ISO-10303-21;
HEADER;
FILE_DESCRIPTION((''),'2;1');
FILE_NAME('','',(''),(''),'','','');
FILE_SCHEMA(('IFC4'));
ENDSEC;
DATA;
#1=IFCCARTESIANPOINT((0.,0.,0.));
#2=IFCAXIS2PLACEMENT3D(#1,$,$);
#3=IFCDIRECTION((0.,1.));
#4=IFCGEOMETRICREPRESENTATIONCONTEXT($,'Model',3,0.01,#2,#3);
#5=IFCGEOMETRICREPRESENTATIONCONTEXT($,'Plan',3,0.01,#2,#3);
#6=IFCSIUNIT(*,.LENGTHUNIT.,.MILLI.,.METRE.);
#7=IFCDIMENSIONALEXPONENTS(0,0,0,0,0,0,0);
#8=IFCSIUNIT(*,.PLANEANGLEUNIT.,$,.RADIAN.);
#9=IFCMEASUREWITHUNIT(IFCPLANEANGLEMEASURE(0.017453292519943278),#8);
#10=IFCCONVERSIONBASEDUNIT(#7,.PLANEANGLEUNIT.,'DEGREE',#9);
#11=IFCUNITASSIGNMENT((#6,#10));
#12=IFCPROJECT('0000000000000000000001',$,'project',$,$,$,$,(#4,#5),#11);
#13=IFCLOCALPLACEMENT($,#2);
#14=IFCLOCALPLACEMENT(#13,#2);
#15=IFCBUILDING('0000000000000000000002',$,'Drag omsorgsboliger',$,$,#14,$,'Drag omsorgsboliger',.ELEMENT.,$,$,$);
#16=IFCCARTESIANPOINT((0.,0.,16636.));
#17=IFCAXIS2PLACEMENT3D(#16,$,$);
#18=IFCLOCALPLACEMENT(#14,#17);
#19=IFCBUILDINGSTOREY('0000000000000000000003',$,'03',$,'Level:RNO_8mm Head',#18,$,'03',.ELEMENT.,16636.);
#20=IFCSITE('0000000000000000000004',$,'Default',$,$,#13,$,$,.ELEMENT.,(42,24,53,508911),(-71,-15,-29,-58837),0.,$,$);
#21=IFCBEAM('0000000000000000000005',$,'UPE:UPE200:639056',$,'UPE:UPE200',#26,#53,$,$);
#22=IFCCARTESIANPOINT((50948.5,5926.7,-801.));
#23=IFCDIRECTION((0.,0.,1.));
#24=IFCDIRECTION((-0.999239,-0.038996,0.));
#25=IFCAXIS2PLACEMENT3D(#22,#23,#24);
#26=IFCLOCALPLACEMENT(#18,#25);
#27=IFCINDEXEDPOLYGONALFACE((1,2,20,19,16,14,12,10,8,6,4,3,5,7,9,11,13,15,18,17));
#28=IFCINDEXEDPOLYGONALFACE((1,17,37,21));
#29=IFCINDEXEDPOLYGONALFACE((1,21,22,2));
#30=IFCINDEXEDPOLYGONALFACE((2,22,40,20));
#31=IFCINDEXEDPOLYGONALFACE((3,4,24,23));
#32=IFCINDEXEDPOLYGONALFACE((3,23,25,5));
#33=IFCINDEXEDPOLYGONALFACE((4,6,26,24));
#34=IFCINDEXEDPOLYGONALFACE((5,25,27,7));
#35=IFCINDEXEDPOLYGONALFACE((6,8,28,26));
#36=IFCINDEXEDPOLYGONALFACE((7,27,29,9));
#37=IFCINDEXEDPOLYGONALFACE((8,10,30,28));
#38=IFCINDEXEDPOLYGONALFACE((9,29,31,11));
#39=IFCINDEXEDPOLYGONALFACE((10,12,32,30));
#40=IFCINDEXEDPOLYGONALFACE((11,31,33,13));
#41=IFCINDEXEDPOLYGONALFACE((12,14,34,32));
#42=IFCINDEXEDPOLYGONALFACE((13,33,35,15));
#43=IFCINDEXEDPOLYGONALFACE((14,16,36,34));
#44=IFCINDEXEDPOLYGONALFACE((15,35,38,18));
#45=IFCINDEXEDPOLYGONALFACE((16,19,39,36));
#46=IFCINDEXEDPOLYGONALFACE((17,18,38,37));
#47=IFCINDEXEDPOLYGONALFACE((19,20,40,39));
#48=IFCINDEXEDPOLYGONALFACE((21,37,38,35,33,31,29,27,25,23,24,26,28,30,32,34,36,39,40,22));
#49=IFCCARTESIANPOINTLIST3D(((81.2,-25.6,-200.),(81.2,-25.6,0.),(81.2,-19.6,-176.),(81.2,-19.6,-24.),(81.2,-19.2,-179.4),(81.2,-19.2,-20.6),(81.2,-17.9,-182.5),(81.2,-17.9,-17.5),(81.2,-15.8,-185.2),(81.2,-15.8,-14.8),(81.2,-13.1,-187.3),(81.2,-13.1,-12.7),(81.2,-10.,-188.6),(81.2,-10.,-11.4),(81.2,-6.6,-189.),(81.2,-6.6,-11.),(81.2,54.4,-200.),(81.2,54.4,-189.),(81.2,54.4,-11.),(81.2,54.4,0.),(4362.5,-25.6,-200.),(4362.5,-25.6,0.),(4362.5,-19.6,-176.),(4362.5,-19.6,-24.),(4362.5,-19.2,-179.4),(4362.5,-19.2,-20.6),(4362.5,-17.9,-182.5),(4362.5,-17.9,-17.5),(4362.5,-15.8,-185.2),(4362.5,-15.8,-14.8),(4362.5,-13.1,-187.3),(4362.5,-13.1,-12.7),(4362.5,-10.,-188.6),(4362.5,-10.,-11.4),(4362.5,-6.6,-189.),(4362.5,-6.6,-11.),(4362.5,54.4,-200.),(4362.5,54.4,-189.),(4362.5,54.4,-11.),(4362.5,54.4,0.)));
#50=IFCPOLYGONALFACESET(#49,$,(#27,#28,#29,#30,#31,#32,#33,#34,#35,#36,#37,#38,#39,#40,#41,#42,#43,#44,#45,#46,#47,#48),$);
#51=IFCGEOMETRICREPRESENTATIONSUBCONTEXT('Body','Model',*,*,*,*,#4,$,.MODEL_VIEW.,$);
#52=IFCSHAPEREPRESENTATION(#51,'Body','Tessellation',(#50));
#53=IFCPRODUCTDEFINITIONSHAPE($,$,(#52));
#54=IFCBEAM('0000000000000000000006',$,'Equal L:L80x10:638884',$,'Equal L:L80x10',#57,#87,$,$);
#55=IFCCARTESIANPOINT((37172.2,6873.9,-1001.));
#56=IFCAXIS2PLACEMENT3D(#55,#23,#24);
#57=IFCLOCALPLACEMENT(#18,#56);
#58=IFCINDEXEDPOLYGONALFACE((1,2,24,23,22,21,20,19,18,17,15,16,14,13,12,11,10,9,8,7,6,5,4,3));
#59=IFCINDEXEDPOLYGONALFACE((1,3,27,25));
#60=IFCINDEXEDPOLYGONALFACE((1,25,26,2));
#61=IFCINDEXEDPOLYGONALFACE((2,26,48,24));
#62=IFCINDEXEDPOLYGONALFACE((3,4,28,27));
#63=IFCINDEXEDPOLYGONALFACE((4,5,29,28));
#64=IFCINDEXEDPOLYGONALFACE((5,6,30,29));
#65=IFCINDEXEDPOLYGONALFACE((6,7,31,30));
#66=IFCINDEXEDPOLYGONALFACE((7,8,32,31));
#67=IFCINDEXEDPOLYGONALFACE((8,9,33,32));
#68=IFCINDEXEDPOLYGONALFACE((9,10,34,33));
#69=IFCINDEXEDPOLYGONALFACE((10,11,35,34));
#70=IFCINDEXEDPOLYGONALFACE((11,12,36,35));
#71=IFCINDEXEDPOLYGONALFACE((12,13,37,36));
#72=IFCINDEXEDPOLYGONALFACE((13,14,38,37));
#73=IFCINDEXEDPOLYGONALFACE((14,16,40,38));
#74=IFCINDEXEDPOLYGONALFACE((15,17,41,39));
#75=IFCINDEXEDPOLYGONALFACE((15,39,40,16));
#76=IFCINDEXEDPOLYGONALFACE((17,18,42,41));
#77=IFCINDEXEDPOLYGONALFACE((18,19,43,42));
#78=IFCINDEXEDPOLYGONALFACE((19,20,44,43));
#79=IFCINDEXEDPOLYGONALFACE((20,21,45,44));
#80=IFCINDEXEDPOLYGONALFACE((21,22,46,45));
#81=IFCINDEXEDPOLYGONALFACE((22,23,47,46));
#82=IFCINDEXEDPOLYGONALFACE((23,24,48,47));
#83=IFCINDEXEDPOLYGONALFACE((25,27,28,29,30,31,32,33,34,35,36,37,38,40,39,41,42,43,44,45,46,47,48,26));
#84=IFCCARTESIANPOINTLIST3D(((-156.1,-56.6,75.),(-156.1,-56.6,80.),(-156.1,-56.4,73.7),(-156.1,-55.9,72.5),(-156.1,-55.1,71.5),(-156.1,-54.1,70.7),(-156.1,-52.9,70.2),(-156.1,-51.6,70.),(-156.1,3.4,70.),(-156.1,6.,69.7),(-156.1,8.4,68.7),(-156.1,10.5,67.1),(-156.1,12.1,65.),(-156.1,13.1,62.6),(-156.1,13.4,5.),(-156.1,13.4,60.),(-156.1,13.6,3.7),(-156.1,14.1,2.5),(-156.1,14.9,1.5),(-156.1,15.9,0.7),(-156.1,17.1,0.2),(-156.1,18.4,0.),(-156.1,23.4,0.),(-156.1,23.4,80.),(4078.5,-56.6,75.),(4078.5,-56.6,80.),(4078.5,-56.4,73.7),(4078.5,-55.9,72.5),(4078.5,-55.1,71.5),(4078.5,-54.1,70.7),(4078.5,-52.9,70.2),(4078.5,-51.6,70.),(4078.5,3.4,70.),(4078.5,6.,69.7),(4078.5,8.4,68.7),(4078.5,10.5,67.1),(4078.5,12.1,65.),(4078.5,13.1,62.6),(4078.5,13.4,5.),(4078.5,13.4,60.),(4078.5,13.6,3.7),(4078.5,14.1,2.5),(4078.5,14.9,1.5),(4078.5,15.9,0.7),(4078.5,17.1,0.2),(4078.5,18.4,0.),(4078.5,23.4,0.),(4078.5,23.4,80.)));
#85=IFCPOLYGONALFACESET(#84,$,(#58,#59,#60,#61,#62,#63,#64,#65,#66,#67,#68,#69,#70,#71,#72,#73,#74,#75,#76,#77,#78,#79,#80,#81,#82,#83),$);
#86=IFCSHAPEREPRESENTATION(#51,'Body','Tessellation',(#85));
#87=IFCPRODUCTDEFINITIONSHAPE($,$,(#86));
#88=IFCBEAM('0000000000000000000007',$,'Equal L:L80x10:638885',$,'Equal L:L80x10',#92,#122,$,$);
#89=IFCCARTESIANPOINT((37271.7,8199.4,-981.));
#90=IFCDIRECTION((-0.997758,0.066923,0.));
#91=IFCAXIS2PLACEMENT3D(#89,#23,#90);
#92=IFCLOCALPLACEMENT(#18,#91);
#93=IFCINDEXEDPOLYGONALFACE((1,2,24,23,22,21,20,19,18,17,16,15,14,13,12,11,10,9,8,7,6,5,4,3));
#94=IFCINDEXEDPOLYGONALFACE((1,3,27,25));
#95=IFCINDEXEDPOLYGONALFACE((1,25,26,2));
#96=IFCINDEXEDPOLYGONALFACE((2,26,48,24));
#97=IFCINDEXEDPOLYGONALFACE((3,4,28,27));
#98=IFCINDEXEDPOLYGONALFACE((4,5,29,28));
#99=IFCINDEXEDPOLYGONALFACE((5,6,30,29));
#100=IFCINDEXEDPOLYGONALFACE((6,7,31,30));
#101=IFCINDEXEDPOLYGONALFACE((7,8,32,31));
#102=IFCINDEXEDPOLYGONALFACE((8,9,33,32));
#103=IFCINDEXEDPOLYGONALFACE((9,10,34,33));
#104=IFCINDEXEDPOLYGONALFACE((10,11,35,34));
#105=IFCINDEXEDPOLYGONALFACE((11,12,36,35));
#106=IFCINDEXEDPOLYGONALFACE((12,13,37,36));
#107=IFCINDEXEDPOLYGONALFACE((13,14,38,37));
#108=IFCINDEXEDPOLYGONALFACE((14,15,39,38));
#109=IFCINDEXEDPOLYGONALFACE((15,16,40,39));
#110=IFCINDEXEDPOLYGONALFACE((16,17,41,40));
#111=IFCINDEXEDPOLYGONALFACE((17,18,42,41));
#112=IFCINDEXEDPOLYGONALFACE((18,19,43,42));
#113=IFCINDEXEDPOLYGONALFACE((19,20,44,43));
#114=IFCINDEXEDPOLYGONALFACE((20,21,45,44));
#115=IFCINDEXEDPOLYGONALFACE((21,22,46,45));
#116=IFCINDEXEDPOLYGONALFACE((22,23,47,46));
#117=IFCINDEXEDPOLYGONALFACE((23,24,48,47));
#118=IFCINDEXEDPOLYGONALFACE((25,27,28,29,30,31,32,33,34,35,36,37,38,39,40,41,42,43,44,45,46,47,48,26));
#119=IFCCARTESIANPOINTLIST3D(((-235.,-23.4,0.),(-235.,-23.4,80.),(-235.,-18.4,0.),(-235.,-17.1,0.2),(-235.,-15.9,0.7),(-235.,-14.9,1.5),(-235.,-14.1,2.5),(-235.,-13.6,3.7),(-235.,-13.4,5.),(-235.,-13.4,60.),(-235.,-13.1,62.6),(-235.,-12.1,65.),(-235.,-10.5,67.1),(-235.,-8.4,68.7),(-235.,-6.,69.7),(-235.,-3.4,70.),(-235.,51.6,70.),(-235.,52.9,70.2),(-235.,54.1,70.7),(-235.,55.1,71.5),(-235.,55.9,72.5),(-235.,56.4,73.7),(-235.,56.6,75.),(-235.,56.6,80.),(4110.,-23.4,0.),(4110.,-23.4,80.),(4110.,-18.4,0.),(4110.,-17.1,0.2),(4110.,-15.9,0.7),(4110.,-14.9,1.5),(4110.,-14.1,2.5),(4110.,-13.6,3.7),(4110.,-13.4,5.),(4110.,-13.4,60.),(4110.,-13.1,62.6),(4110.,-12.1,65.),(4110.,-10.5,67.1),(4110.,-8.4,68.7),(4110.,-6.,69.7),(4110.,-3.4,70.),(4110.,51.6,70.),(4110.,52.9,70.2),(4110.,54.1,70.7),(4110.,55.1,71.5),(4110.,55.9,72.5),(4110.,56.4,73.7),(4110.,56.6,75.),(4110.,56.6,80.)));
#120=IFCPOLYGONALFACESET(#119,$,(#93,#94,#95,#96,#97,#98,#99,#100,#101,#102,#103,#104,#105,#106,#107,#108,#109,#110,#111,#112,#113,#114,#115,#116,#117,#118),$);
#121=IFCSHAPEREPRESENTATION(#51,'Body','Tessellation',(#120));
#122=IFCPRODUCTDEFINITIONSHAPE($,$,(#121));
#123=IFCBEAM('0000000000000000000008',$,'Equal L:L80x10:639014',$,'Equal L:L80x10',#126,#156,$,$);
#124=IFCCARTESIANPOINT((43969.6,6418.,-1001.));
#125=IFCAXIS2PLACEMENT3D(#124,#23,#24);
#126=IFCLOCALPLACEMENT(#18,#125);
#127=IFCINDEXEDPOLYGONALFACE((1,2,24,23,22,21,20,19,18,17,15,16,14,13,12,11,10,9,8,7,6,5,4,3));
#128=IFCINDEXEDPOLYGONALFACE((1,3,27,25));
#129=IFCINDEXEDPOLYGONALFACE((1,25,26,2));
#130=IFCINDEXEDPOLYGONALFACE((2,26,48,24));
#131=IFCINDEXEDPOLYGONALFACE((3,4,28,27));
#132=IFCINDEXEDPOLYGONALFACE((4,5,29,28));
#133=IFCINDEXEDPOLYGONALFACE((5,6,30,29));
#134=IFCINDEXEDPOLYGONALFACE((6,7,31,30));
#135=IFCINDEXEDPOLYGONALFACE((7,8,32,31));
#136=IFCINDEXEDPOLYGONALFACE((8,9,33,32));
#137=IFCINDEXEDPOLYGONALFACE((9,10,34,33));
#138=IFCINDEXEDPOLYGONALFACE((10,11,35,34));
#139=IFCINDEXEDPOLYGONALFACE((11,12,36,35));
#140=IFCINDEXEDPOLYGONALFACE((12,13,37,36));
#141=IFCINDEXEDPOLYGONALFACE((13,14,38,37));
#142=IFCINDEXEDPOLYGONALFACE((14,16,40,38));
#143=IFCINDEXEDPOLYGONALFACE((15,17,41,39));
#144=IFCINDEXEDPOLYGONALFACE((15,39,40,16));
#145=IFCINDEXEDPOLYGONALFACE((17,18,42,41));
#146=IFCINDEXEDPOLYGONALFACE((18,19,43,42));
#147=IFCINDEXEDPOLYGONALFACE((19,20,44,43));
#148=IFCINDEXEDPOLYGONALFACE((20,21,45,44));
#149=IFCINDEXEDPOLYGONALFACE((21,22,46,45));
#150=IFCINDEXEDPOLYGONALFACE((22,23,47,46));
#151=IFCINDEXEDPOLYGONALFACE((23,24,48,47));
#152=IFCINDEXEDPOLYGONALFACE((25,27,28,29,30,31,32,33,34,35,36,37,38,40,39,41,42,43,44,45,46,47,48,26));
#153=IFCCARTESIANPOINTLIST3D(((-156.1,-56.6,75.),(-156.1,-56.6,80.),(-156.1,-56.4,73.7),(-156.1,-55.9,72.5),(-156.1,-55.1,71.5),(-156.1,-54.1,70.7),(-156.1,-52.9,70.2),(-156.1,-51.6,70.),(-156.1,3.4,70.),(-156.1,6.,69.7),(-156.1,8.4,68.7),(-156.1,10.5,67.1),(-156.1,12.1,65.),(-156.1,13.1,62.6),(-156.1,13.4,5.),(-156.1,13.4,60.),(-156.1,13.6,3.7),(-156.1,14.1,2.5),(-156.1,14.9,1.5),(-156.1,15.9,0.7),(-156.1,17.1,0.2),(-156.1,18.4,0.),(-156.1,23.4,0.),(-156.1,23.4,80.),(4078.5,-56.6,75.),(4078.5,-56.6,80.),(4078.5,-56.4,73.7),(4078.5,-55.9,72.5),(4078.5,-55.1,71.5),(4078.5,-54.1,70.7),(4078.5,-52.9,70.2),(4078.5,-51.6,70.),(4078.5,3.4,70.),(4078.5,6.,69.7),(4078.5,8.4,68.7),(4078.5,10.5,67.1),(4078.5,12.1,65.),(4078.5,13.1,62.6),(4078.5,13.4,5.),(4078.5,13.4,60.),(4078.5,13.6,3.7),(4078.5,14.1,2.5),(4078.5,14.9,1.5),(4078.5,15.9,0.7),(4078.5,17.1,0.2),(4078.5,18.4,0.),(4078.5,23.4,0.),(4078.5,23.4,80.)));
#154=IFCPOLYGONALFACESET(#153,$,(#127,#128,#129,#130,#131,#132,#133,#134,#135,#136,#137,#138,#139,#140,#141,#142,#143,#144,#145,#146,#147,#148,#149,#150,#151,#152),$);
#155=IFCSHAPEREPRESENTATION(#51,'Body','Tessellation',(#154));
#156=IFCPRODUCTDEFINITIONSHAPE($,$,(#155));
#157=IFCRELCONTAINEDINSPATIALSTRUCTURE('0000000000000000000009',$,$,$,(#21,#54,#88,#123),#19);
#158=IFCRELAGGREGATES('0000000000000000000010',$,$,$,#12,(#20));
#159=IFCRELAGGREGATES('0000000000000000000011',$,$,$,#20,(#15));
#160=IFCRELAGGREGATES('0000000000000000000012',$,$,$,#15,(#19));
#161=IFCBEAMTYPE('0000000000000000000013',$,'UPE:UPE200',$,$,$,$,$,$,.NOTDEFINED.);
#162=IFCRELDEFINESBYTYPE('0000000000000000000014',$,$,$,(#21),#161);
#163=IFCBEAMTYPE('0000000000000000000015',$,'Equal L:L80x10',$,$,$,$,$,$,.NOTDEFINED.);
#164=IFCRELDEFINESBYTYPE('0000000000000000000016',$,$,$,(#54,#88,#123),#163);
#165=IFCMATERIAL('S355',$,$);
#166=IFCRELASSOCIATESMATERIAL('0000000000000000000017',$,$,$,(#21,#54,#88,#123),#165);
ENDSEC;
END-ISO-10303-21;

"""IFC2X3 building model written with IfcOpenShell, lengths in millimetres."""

from ifc_helpers import new_model, entity, si_unit, converted_unit, direction, frame, frame_2d, origin, place, context, subcontext, project, spatial, polyline, circle_curve, parameter, trimmed, segment, composite_curve, outline, extrude, material, type_object, element, save


model = new_model("IFC2X3")

# Units and contexts
model_context = context("Model", 3, precision=0.01, world=origin(), true_north=direction((0.0, 1.0)))
plan_context = context("Plan", 3, precision=0.01, world=origin(), true_north=direction((0.0, 1.0)))
body_context = subcontext(model_context, "Body", "Model", "MODEL_VIEW")
ifc_project = project(units=[si_unit("LENGTHUNIT", "METRE", prefix="MILLI"), converted_unit("PLANEANGLEUNIT", "DEGREE", entity("IfcPlaneAngleMeasure", 0.017453292519943278), si_unit("PLANEANGLEUNIT", "RADIAN"), dimensions=[0, 0, 0, 0, 0, 0, 0])], contexts=[model_context, plan_context])

# Site, building, storey
site_placement = place(None, origin())
site = spatial("IfcSite", under=ifc_project, at=site_placement, Name="Default", CompositionType="ELEMENT", RefLatitude=(42, 24, 53, 508911), RefLongitude=(-71, -15, -29, -58837), RefElevation=0.0)
building_placement = place(site_placement, origin())
building = spatial("IfcBuilding", under=site, at=building_placement, Name="Drag omsorgsboliger", LongName="Drag omsorgsboliger", CompositionType="ELEMENT")
storey_placement = place(building_placement, frame((0.0, 0.0, 16636.0)))
storey = spatial("IfcBuildingStorey", under=building, at=storey_placement, Name="03", ObjectType="Level:RNO_8mm Head", LongName="03", CompositionType="ELEMENT", Elevation=16636.0)

# Beams
ifc_material = material(Name="S355")
beam_type_1 = type_object("IfcBeamType", Name="UPE:UPE200", PredefinedType="NOTDEFINED")
beam_1_placement = place(storey_placement, frame((50948.5, 5926.7, -801.0), z_axis=(0.0, 0.0, 1.0), x_axis=(-0.999239, -0.038996, 0.0)))
element("IfcBeam", 1, at=beam_1_placement, inside=storey, type_object=beam_type_1, material=ifc_material, Name="UPE:UPE200:639056", ObjectType="UPE:UPE200", context=body_context, shape_type="SweptSolid", body=[
    extrude(outline(composite_curve([segment(polyline([(-100.0, -37.0), (100.0, -37.0)]), True, "CONTINUOUS"), segment(polyline([(100.0, -37.0), (100.0, 43.0)]), True, "CONTINUOUS"), segment(polyline([(100.0, 43.0), (89.0, 43.0)]), True, "CONTINUOUS"), segment(polyline([(89.0, 43.0), (89.0, -18.0)]), True, "CONTINUOUS"), segment(trimmed(circle_curve(frame_2d((76.0, -18.0), x_axis=(1.0, 0.0)), 13.0), [parameter(270.0)], [parameter(0.0)], True, "PARAMETER"), False, "CONTINUOUS"), segment(polyline([(76.0, -31.0), (-76.0, -31.0)]), True, "CONTINUOUS"), segment(trimmed(circle_curve(frame_2d((-76.0, -18.0), x_axis=(0.0, -1.0)), 13.0), [parameter(270.0)], [parameter(0.0)], True, "PARAMETER"), False, "CONTINUOUS"), segment(polyline([(-89.0, -18.0), (-89.0, 43.0)]), True, "CONTINUOUS"), segment(polyline([(-89.0, 43.0), (-100.0, 43.0)]), True, "CONTINUOUS"), segment(polyline([(-100.0, 43.0), (-100.0, -37.0)]), True, "CONTINUOUS")], self_intersect=False)), frame((81.2, 11.4, -100.0), z_axis=(1.0, 0.0, 0.0), x_axis=(0.0, 0.0, -1.0)), (0.0, 0.0, 1.0), 4281.3),
])
beam_type_2 = type_object("IfcBeamType", Name="Equal L:L80x10", PredefinedType="NOTDEFINED")
beam_2_placement = place(storey_placement, frame((37172.2, 6873.9, -1001.0), z_axis=(0.0, 0.0, 1.0), x_axis=(-0.999239, -0.038996, 0.0)))
element("IfcBeam", 2, at=beam_2_placement, inside=storey, type_object=beam_type_2, material=ifc_material, Name="Equal L:L80x10:638884", ObjectType="Equal L:L80x10", context=body_context, shape_type="SweptSolid", body=[
    extrude(outline(composite_curve([segment(polyline([(-31.1, -48.9), (-26.1, -48.9)]), True, "CONTINUOUS"), segment(trimmed(circle_curve(frame_2d((-26.1, -43.9), x_axis=(0.0, -1.0)), 5.0), [parameter(0.0)], [parameter(90.0)], True, "PARAMETER"), True, "CONTINUOUS"), segment(polyline([(-21.1, -43.9), (-21.1, 11.1)]), True, "CONTINUOUS"), segment(trimmed(circle_curve(frame_2d((-11.1, 11.1), x_axis=(-1.0, 0.0)), 10.0), [parameter(270.0)], [parameter(0.0)], True, "PARAMETER"), False, "CONTINUOUS"), segment(polyline([(-11.1, 21.1), (43.9, 21.1)]), True, "CONTINUOUS"), segment(trimmed(circle_curve(frame_2d((43.9, 26.1), x_axis=(0.0, -1.0)), 5.0), [parameter(0.0)], [parameter(90.0)], True, "PARAMETER"), True, "CONTINUOUS"), segment(polyline([(48.9, 26.1), (48.9, 31.1)]), True, "CONTINUOUS"), segment(polyline([(48.9, 31.1), (-31.1, 31.1)]), True, "CONTINUOUS"), segment(polyline([(-31.1, 31.1), (-31.1, -48.9)]), True, "CONTINUOUS")], self_intersect=False)), frame((-156.1, -7.7, 48.9), z_axis=(1.0, 0.0, 0.0), x_axis=(0.0, 0.0, -1.0)), (0.0, 0.0, 1.0), 4234.6),
])
beam_3_placement = place(storey_placement, frame((37271.7, 8199.4, -981.0), z_axis=(0.0, 0.0, 1.0), x_axis=(-0.997758, 0.066923, 0.0)))
element("IfcBeam", 3, at=beam_3_placement, inside=storey, type_object=beam_type_2, material=ifc_material, Name="Equal L:L80x10:638885", ObjectType="Equal L:L80x10", context=body_context, shape_type="SweptSolid", body=[
    extrude(outline(composite_curve([segment(polyline([(-31.1, -31.1), (48.9, -31.1)]), True, "CONTINUOUS"), segment(polyline([(48.9, -31.1), (48.9, -26.1)]), True, "CONTINUOUS"), segment(trimmed(circle_curve(frame_2d((43.9, -26.1), x_axis=(1.0, 0.0)), 5.0), [parameter(0.0)], [parameter(90.0)], True, "PARAMETER"), True, "CONTINUOUS"), segment(polyline([(43.9, -21.1), (-11.1, -21.1)]), True, "CONTINUOUS"), segment(trimmed(circle_curve(frame_2d((-11.1, -11.1), x_axis=(0.0, -1.0)), 10.0), [parameter(270.0)], [parameter(0.0)], True, "PARAMETER"), False, "CONTINUOUS"), segment(polyline([(-21.1, -11.1), (-21.1, 43.9)]), True, "CONTINUOUS"), segment(trimmed(circle_curve(frame_2d((-26.1, 43.9), x_axis=(1.0, 0.0)), 5.0), [parameter(0.0)], [parameter(90.0)], True, "PARAMETER"), True, "CONTINUOUS"), segment(polyline([(-26.1, 48.9), (-31.1, 48.9)]), True, "CONTINUOUS"), segment(polyline([(-31.1, 48.9), (-31.1, -31.1)]), True, "CONTINUOUS")], self_intersect=False)), frame((-235.0, 7.7, 48.9), z_axis=(1.0, 0.0, 0.0), x_axis=(0.0, 0.0, -1.0)), (0.0, 0.0, 1.0), 4345.0),
])
beam_4_placement = place(storey_placement, frame((43969.6, 6418.0, -1001.0), z_axis=(0.0, 0.0, 1.0), x_axis=(-0.999239, -0.038996, 0.0)))
element("IfcBeam", 4, at=beam_4_placement, inside=storey, type_object=beam_type_2, material=ifc_material, Name="Equal L:L80x10:639014", ObjectType="Equal L:L80x10", context=body_context, shape_type="SweptSolid", body=[
    extrude(outline(composite_curve([segment(polyline([(-31.1, -48.9), (-26.1, -48.9)]), True, "CONTINUOUS"), segment(trimmed(circle_curve(frame_2d((-26.1, -43.9), x_axis=(0.0, -1.0)), 5.0), [parameter(0.0)], [parameter(90.0)], True, "PARAMETER"), True, "CONTINUOUS"), segment(polyline([(-21.1, -43.9), (-21.1, 11.1)]), True, "CONTINUOUS"), segment(trimmed(circle_curve(frame_2d((-11.1, 11.1), x_axis=(-1.0, 0.0)), 10.0), [parameter(270.0)], [parameter(0.0)], True, "PARAMETER"), False, "CONTINUOUS"), segment(polyline([(-11.1, 21.1), (43.9, 21.1)]), True, "CONTINUOUS"), segment(trimmed(circle_curve(frame_2d((43.9, 26.1), x_axis=(0.0, -1.0)), 5.0), [parameter(0.0)], [parameter(90.0)], True, "PARAMETER"), True, "CONTINUOUS"), segment(polyline([(48.9, 26.1), (48.9, 31.1)]), True, "CONTINUOUS"), segment(polyline([(48.9, 31.1), (-31.1, 31.1)]), True, "CONTINUOUS"), segment(polyline([(-31.1, 31.1), (-31.1, -48.9)]), True, "CONTINUOUS")], self_intersect=False)), frame((-156.1, -7.7, 48.9), z_axis=(1.0, 0.0, 0.0), x_axis=(0.0, 0.0, -1.0)), (0.0, 0.0, 1.0), 4234.6),
])

save(model, "model.ifc")
